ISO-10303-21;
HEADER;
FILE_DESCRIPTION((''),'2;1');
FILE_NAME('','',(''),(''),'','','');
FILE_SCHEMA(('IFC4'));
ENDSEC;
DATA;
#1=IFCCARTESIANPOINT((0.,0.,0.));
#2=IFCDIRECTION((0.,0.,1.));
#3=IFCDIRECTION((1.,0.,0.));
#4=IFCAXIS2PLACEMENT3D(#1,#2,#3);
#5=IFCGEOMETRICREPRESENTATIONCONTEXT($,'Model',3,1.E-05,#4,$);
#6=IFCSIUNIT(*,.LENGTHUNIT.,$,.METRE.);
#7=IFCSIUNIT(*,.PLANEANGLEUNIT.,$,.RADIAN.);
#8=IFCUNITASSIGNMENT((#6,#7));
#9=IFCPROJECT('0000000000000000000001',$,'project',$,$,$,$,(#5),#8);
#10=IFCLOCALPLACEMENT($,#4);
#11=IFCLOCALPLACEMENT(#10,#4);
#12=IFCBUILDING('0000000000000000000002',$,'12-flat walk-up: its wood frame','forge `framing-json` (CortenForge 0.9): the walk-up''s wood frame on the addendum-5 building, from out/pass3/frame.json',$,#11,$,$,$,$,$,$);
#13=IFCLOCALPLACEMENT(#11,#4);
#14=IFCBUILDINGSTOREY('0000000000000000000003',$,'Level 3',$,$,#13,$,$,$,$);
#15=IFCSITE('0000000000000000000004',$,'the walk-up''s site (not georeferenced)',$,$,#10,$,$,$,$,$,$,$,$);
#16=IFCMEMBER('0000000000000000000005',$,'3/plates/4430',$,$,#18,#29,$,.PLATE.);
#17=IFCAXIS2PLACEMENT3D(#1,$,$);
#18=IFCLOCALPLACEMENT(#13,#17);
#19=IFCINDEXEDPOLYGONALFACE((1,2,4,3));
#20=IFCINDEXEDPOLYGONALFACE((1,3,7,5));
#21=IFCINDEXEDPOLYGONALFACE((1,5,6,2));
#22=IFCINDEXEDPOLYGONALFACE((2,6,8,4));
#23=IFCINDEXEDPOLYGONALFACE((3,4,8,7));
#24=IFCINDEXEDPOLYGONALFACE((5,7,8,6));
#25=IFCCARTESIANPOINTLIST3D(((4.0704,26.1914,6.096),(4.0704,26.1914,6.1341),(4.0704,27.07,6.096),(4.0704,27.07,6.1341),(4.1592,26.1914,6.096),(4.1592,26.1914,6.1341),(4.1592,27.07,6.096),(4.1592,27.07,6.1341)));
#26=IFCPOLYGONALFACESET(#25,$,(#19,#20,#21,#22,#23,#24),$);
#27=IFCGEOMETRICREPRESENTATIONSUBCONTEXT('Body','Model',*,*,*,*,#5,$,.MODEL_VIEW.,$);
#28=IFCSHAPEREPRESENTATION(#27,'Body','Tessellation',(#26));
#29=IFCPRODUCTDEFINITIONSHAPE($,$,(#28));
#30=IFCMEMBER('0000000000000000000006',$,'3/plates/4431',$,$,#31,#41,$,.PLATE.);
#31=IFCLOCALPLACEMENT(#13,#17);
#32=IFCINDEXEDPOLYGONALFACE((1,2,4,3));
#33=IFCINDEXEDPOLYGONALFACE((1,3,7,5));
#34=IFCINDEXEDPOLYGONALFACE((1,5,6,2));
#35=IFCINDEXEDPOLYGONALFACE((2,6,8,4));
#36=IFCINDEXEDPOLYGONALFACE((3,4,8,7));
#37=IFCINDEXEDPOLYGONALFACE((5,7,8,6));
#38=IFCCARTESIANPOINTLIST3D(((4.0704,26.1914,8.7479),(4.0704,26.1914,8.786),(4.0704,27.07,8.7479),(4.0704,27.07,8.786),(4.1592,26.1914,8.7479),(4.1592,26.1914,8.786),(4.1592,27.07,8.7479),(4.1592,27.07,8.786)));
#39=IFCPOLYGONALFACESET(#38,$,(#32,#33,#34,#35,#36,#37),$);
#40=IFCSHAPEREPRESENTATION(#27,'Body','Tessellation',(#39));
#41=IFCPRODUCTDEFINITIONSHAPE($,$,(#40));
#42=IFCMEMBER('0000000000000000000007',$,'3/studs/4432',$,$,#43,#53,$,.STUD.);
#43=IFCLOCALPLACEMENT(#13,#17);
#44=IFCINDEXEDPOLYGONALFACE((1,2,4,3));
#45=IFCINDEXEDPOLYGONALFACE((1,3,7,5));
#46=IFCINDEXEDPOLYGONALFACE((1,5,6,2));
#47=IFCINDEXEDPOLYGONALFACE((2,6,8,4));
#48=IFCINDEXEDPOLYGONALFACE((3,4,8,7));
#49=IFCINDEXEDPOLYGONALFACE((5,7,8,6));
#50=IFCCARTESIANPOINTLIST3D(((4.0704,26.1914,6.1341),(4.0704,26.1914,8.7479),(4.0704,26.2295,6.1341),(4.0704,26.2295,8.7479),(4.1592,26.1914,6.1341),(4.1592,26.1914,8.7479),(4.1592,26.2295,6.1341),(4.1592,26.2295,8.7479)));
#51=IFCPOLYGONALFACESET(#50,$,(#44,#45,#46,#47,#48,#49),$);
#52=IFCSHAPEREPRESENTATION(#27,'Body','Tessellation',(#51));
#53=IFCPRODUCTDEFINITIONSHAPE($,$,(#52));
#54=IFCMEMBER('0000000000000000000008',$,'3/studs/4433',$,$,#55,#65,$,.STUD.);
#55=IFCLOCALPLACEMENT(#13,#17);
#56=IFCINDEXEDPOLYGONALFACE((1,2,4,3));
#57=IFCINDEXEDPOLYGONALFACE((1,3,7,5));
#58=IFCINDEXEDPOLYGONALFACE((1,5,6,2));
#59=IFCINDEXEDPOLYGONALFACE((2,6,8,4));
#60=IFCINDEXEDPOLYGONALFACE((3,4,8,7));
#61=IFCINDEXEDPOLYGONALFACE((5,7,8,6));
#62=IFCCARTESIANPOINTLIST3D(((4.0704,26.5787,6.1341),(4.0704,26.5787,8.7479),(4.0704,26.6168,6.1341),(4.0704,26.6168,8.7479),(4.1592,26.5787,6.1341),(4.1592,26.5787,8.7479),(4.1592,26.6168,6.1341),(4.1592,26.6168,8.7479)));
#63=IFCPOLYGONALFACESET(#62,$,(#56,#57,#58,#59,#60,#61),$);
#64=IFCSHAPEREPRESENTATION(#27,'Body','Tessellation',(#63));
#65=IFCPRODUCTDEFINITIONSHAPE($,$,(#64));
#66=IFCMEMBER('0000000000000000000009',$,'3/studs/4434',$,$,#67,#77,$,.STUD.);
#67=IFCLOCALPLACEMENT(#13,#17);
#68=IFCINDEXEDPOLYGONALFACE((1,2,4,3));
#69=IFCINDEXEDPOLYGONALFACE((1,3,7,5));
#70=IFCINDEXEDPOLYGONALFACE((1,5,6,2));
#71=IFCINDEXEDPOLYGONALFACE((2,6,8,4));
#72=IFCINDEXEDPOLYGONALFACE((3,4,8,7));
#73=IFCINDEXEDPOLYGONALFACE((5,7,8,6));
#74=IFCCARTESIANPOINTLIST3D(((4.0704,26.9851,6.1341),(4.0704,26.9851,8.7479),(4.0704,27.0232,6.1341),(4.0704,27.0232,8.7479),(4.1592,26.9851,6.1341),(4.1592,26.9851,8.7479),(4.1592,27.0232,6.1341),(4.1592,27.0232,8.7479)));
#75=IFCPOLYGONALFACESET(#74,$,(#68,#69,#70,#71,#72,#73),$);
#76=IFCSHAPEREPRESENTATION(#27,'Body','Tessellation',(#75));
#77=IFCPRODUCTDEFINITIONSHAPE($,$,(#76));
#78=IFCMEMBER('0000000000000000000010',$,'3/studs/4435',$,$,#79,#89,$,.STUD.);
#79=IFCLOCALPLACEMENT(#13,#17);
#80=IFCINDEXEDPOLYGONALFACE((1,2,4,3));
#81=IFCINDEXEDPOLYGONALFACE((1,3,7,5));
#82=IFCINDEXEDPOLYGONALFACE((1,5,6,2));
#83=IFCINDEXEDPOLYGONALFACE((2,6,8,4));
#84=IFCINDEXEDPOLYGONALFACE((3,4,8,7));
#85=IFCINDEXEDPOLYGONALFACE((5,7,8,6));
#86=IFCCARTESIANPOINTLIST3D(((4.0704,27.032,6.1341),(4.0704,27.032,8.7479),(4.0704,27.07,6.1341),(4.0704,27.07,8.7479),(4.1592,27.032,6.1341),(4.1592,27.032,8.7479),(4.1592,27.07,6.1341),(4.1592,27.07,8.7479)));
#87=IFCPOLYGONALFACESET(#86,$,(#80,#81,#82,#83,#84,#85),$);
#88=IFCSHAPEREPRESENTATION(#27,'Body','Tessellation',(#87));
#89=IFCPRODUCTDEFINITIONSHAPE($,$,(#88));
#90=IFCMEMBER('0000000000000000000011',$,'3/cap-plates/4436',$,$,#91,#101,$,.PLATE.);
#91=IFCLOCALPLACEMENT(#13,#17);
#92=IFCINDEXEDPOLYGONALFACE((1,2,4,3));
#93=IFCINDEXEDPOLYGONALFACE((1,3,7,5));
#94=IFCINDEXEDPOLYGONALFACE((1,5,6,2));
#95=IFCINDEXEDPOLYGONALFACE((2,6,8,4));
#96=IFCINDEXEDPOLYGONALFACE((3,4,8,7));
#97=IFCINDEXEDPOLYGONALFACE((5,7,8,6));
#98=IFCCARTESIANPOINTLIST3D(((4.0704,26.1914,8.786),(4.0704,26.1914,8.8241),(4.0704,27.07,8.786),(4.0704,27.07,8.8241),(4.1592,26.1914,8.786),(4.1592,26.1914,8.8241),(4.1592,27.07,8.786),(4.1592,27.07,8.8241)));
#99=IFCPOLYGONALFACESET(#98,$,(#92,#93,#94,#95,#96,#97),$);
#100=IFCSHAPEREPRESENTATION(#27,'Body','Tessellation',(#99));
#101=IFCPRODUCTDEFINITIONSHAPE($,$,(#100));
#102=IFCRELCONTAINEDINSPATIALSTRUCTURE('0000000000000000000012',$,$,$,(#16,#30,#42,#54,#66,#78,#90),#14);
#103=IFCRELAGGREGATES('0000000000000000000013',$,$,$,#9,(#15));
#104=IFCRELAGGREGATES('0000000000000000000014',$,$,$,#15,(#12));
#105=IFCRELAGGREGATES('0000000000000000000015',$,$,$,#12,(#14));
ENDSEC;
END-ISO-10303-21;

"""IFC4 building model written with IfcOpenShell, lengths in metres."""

from ifc_helpers import new_model, si_unit, frame, frame_2d, origin, origin_with_axes, place, context, subcontext, project, spatial, rectangle, extrude, element, save


model = new_model("IFC4")

# Units and contexts
model_context = context("Model", 3, precision=1e-05, world=origin_with_axes())
body_context = subcontext(model_context, "Body", "Model", "MODEL_VIEW")
ifc_project = project(units=[si_unit("LENGTHUNIT", "METRE"), si_unit("PLANEANGLEUNIT", "RADIAN")], contexts=[model_context])

# Site, building, storey
site_placement = place(None, origin_with_axes())
site = spatial("IfcSite", under=ifc_project, at=site_placement, Name="the walk-up's site (not georeferenced)")
building_placement = place(site_placement, origin_with_axes())
building = spatial("IfcBuilding", under=site, at=building_placement, Name="12-flat walk-up: its wood frame", Description="forge `framing-json` (CortenForge 0.9): the walk-up's wood frame on the addendum-5 building, from out/pass3/frame.json")
storey_placement = place(building_placement, origin_with_axes())
storey = spatial("IfcBuildingStorey", under=building, at=storey_placement, Name="Level 3")

# Members
for number, where, z_axis, x_axis, name in (
    (1, (4.0704, 26.1914, 6.096), (0.0, 0.0, 1.0), (1.0, 0.0, 0.0), "3/plates/4430"),
    (2, (4.0704, 26.1914, 8.7479), (0.0, 0.0, 1.0), (1.0, 0.0, 0.0), "3/plates/4431"),
):
    element("IfcMember", number, at=place(storey_placement, frame(where, z_axis=z_axis, x_axis=x_axis)), inside=storey, Name=name, PredefinedType="PLATE", context=body_context, shape_type="SweptSolid", body=[
        extrude(rectangle(XDim=0.0889, YDim=0.8787, at=frame_2d((0.0444, 0.4393))), origin(), (0.0, 0.0, 1.0), 0.0381),
    ])
for number, where, z_axis, x_axis, name in (
    (3, (4.0704, 26.1914, 6.1341), (0.0, 0.0, 1.0), (1.0, 0.0, 0.0), "3/studs/4432"),
    (4, (4.0704, 26.5787, 6.1341), (0.0, 0.0, 1.0), (1.0, 0.0, 0.0), "3/studs/4433"),
    (5, (4.0704, 26.9851, 6.1341), (0.0, 0.0, 1.0), (1.0, 0.0, 0.0), "3/studs/4434"),
    (6, (4.0704, 27.0319, 6.1341), (0.0, 0.0, 1.0), (1.0, 0.0, 0.0), "3/studs/4435"),
):
    element("IfcMember", number, at=place(storey_placement, frame(where, z_axis=z_axis, x_axis=x_axis)), inside=storey, Name=name, PredefinedType="STUD", context=body_context, shape_type="SweptSolid", body=[
        extrude(rectangle(XDim=0.0889, YDim=0.0381, at=frame_2d((0.0444, 0.0191))), origin(), (0.0, 0.0, 1.0), 2.6138),
    ])
member_1_placement = place(storey_placement, frame((4.0704, 26.1914, 8.786), z_axis=(0.0, 0.0, 1.0), x_axis=(1.0, 0.0, 0.0)))
element("IfcMember", 7, at=member_1_placement, inside=storey, Name="3/cap-plates/4436", PredefinedType="PLATE", context=body_context, shape_type="SweptSolid", body=[
    extrude(rectangle(XDim=0.0889, YDim=0.8787, at=frame_2d((0.0444, 0.4393))), origin(), (0.0, 0.0, 1.0), 0.0381),
])

save(model, "model.ifc")
